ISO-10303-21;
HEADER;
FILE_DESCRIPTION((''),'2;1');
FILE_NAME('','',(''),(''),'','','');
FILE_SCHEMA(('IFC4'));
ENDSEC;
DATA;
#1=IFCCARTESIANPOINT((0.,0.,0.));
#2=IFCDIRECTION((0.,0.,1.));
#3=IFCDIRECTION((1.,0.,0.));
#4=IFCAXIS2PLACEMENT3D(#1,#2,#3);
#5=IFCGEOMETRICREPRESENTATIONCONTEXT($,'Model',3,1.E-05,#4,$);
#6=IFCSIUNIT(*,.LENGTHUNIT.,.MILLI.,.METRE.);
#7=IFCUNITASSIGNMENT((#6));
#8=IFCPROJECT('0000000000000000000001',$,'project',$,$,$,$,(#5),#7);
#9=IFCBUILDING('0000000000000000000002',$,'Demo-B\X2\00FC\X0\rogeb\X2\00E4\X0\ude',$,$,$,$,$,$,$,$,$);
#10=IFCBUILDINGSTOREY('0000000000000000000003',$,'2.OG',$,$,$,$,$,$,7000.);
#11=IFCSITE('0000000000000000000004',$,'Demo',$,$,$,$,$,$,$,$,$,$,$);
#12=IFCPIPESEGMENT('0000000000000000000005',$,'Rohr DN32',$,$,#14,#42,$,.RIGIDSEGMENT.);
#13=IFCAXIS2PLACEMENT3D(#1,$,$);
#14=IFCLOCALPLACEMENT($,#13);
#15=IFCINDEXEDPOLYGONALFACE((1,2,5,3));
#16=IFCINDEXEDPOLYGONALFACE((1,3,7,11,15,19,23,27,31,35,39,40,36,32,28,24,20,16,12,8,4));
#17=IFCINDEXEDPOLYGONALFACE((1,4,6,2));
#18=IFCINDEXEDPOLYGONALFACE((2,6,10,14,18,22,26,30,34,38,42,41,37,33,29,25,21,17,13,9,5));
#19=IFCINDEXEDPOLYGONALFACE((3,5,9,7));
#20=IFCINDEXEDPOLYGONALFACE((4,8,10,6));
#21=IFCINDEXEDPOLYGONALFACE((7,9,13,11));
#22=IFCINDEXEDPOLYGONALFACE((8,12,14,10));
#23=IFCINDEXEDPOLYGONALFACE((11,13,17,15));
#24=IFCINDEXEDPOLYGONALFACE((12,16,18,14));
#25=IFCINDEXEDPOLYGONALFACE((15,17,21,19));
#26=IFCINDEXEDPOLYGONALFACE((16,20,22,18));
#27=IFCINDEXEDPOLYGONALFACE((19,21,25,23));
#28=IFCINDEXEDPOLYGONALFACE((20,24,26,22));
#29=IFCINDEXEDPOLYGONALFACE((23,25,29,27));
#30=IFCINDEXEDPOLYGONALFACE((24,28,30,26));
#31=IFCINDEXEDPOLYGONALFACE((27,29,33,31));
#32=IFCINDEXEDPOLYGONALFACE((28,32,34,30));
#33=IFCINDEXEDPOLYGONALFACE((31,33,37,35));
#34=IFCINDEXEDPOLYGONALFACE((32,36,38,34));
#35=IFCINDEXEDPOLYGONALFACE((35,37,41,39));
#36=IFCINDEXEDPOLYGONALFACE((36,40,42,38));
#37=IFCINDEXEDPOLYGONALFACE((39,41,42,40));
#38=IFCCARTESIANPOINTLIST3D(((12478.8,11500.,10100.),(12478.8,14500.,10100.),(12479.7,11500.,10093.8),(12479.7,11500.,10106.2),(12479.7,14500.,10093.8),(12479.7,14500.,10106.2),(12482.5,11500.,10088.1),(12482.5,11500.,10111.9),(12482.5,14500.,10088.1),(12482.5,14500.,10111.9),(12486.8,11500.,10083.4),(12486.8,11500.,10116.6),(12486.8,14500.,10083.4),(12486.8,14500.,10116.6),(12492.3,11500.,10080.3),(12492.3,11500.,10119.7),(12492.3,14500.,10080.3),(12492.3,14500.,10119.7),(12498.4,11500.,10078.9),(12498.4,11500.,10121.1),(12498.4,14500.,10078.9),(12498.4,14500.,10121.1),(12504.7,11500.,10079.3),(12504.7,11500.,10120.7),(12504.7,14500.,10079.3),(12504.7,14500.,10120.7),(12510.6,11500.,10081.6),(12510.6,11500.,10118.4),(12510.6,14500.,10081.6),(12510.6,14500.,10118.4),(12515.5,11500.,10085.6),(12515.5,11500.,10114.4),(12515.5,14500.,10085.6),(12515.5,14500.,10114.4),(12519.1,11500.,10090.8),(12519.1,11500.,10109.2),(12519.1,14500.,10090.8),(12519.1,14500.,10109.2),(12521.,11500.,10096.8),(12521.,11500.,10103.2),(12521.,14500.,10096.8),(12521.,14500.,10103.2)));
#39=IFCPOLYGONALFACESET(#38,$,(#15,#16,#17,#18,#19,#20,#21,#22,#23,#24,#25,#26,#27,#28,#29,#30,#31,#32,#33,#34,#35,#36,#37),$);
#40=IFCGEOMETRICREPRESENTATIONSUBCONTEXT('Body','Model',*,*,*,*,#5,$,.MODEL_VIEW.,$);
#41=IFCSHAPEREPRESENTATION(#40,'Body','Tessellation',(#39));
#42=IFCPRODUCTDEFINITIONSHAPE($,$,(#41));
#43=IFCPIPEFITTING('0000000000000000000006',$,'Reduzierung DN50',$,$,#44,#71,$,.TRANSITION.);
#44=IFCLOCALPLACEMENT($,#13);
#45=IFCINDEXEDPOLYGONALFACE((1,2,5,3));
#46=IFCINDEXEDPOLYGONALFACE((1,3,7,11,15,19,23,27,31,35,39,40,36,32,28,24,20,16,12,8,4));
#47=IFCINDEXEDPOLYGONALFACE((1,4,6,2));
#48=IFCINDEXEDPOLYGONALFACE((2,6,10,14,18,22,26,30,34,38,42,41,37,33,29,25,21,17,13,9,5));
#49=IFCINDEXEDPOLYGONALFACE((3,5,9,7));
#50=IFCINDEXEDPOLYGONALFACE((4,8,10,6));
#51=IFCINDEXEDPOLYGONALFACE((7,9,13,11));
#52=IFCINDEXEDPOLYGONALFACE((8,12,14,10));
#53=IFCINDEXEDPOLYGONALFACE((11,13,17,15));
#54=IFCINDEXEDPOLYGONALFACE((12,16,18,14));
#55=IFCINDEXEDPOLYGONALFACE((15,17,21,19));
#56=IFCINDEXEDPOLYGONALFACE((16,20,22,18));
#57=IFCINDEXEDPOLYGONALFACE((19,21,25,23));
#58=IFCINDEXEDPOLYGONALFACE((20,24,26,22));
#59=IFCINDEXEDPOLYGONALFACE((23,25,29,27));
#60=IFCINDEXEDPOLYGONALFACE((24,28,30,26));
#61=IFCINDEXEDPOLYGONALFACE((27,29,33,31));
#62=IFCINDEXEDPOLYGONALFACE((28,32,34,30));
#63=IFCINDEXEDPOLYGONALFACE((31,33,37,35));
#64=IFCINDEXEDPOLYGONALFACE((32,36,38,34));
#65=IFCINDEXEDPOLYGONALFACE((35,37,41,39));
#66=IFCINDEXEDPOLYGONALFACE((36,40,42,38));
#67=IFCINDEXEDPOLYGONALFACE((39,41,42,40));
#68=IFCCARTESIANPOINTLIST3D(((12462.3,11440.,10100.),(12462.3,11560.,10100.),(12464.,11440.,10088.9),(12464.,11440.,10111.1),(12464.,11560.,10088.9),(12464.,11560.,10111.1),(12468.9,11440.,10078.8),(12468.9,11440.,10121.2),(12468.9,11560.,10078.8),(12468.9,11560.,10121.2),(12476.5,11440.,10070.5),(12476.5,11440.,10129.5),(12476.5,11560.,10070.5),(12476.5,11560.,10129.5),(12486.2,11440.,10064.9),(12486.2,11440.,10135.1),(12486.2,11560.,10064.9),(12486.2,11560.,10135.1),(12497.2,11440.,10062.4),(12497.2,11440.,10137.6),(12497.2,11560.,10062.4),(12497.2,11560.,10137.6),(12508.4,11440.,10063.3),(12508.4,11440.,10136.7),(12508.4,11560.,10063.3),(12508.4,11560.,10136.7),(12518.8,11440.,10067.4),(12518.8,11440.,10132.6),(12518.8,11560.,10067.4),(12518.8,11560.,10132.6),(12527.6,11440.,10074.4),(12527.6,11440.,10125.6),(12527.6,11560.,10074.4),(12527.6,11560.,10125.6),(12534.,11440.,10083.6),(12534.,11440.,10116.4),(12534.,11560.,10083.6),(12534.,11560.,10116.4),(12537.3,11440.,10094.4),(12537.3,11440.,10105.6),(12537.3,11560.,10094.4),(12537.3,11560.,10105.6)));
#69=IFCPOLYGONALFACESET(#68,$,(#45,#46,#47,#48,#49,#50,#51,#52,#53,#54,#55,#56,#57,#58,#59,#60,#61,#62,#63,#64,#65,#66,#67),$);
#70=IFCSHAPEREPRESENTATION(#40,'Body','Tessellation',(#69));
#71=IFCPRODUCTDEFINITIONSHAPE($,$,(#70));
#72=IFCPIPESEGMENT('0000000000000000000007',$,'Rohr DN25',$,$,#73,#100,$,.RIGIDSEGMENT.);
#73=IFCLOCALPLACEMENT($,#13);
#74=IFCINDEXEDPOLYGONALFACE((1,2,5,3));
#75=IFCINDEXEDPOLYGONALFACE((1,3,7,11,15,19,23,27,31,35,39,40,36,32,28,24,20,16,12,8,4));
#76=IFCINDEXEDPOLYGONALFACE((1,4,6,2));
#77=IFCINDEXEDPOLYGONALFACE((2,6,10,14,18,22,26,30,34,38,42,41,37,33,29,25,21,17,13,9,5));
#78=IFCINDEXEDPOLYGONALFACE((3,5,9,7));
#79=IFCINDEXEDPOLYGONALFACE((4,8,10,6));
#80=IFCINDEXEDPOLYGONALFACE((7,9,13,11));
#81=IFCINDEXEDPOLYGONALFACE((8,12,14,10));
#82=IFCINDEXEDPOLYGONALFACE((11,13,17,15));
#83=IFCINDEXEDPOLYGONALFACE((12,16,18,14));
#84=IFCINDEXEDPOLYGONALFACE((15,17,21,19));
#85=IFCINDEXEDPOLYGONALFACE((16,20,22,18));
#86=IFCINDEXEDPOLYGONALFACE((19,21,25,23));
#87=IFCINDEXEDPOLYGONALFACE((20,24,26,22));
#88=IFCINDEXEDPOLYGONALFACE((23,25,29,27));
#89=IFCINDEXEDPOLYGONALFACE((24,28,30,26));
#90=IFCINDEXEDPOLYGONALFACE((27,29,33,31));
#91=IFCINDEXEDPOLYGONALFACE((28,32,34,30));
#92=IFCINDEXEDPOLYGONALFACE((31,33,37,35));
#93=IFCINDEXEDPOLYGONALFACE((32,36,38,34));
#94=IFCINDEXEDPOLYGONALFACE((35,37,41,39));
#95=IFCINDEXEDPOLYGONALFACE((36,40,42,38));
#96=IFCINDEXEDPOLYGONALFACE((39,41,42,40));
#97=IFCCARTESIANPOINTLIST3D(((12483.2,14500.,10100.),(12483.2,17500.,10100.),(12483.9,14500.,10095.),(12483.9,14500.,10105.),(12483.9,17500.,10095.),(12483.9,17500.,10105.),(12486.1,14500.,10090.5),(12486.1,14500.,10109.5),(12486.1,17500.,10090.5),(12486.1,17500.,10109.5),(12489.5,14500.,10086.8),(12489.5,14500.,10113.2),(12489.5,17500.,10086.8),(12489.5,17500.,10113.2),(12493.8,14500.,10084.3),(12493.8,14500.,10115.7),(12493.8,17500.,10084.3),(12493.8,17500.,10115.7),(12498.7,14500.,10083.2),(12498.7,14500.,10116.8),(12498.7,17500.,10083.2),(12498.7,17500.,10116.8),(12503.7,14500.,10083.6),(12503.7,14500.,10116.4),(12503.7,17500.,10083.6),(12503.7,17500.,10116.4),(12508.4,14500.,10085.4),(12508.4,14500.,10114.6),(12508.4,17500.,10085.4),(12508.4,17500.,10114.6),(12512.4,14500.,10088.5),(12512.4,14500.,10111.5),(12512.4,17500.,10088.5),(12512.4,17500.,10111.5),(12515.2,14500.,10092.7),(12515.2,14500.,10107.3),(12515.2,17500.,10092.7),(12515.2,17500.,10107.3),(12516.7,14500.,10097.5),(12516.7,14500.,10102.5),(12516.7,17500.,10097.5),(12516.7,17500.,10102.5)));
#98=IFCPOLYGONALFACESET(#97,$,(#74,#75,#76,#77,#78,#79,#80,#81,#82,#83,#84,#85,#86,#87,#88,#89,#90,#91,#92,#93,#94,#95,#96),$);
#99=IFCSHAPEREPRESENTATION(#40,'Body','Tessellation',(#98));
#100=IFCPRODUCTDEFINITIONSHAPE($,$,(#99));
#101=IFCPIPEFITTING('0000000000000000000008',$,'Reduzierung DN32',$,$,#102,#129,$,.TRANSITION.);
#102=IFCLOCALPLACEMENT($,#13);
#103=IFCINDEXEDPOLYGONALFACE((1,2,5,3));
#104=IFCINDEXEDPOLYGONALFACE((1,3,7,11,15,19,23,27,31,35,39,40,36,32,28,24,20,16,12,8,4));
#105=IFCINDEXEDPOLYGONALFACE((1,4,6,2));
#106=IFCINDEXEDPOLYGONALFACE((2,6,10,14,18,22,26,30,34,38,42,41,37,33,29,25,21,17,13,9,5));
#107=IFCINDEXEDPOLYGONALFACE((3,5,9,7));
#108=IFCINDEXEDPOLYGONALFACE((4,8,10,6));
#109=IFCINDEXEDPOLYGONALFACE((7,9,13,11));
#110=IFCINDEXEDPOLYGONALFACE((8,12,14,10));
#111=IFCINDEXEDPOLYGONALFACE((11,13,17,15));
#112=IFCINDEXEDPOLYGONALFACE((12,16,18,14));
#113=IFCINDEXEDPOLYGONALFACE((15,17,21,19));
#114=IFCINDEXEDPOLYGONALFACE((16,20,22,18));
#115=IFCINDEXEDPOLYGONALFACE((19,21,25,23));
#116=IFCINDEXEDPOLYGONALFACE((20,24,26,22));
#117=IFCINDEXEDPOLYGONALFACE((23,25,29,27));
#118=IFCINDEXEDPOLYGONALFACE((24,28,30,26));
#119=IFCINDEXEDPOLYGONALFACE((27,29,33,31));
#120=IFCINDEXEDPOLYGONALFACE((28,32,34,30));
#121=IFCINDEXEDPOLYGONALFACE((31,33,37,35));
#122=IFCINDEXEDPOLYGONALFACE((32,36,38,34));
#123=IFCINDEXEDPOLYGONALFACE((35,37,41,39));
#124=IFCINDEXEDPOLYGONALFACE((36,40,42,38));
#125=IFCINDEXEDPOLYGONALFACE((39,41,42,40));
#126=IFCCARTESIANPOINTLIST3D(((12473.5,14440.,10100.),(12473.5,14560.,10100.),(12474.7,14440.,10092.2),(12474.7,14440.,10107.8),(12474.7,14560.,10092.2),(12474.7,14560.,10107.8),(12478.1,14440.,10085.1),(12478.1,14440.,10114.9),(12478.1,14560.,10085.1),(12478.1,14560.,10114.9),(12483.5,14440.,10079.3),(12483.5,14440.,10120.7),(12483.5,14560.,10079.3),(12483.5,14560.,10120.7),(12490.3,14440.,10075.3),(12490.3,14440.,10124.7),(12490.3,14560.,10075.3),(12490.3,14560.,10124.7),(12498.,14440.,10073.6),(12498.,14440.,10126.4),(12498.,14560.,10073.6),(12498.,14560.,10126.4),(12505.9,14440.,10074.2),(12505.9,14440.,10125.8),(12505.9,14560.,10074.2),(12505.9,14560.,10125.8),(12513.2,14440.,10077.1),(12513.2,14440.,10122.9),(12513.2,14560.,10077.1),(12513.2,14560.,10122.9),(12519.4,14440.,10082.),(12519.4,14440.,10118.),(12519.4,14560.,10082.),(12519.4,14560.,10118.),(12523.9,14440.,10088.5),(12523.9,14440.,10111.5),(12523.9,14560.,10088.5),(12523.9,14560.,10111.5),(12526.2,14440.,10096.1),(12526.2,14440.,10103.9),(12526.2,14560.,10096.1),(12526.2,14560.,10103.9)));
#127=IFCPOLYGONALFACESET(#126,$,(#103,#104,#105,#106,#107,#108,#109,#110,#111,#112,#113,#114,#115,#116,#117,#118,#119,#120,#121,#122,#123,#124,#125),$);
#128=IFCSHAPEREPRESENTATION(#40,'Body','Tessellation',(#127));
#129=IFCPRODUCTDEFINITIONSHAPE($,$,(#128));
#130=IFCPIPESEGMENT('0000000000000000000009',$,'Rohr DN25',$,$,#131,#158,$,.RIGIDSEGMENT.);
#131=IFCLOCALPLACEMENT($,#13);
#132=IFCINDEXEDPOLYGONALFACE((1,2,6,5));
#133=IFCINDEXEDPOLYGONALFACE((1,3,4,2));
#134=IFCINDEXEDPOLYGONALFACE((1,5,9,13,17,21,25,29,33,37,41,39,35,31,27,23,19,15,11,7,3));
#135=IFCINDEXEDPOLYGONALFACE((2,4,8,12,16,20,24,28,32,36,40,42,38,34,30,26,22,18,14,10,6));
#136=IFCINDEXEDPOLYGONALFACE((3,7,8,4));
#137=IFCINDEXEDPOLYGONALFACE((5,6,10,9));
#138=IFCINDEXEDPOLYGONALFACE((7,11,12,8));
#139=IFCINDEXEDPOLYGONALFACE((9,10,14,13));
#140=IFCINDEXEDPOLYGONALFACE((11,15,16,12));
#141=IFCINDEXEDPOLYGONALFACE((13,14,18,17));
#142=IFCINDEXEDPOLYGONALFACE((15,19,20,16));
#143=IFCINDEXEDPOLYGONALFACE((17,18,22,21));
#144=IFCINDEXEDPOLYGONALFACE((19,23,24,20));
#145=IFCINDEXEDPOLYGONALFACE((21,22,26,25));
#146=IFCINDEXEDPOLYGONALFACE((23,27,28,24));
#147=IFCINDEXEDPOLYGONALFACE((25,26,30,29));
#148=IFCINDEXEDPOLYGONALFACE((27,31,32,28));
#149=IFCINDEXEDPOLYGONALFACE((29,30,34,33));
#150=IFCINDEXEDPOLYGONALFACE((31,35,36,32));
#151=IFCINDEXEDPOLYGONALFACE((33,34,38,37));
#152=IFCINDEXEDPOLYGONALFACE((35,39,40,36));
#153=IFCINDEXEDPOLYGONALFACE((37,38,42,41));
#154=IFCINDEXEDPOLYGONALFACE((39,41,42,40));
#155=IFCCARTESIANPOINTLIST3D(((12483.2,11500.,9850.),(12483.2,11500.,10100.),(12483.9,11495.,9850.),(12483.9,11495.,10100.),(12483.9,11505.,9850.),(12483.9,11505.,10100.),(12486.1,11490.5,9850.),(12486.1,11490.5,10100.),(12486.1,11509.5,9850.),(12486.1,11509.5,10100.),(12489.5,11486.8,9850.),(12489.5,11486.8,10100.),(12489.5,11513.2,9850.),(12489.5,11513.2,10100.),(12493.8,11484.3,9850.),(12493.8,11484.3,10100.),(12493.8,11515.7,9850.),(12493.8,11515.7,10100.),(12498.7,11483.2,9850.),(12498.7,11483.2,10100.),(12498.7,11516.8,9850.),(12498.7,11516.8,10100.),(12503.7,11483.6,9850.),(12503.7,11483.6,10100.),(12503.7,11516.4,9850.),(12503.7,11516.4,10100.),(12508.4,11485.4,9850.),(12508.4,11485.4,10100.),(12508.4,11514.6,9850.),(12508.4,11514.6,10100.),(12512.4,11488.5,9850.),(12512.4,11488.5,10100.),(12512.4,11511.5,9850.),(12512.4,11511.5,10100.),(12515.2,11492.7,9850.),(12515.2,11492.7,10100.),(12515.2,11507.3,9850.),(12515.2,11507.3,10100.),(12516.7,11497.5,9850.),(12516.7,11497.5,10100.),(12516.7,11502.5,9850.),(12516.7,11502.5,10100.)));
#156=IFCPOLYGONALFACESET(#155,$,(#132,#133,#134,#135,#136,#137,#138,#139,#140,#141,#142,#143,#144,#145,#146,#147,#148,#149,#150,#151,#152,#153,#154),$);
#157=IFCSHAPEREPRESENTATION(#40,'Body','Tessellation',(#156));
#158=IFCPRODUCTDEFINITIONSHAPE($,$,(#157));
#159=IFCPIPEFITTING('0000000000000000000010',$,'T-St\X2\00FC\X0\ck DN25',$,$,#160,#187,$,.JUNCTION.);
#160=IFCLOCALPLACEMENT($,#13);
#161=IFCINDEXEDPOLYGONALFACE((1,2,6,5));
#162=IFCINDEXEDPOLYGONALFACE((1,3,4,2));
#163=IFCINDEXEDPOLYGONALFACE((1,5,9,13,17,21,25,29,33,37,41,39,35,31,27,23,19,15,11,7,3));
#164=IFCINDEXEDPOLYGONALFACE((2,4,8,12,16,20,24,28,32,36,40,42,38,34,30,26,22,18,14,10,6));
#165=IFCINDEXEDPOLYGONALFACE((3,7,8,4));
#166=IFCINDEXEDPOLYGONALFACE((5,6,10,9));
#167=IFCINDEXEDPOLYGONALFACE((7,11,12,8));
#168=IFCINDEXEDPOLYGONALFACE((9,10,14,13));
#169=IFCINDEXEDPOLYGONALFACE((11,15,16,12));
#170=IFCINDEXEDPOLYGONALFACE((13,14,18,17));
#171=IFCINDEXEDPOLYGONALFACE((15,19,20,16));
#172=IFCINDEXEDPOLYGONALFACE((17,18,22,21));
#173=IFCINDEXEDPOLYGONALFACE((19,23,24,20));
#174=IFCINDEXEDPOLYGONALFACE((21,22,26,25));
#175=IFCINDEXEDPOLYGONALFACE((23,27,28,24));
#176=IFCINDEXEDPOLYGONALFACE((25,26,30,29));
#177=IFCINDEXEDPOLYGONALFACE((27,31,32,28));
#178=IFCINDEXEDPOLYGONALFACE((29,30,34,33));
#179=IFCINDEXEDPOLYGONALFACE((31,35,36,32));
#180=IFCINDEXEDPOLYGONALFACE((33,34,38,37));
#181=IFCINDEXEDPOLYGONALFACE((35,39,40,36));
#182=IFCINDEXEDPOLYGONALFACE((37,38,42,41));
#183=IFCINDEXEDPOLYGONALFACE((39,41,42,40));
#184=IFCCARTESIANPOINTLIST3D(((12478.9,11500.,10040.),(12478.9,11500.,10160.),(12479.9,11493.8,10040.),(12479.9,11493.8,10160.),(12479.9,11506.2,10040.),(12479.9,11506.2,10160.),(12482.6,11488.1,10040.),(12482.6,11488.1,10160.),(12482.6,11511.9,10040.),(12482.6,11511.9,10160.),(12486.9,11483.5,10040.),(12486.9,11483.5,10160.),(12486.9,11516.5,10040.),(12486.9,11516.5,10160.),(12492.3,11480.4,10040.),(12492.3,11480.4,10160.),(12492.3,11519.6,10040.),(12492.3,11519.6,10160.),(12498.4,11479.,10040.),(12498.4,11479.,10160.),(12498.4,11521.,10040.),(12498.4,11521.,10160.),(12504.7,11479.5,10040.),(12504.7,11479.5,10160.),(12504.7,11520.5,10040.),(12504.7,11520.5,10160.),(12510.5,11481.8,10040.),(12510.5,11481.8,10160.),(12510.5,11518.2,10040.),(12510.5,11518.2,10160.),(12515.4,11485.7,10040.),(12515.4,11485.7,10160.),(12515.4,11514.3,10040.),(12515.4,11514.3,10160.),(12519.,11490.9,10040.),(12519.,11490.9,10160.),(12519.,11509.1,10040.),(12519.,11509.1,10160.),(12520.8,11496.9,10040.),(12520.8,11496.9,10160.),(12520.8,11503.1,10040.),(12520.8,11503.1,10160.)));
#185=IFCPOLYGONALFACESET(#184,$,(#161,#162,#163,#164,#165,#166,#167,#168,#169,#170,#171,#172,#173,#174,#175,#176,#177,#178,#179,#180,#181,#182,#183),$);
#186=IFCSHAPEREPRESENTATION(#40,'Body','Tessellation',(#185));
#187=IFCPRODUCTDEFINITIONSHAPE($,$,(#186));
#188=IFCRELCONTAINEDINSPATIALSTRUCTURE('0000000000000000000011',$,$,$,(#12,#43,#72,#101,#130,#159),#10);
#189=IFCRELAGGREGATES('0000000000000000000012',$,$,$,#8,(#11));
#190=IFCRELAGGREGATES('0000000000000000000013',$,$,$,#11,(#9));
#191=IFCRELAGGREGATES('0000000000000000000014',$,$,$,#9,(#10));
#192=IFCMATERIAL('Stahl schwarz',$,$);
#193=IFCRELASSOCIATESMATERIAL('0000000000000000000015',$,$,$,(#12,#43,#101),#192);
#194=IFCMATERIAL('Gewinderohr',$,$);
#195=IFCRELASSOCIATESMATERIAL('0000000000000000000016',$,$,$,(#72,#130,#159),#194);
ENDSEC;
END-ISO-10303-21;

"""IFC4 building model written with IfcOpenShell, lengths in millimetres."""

from ifc_helpers import new_model, si_unit, frame, origin_with_axes, place, context, subcontext, project, spatial, circle, extrude, material, element, save


model = new_model("IFC4")

# Units and contexts
model_context = context("Model", 3, precision=1e-05, world=origin_with_axes())
body_context = subcontext(model_context, "Body", "Model", "MODEL_VIEW")
ifc_project = project(units=[si_unit("LENGTHUNIT", "METRE", prefix="MILLI")], contexts=[model_context])

# Site, building, storey
site = spatial("IfcSite", under=ifc_project, Name="Demo")
building = spatial("IfcBuilding", under=site, Name="Demo-Bürogebäude")
storey = spatial("IfcBuildingStorey", under=building, Name="2.OG", Elevation=7000.0)

# Pipe segment
ifc_material_1 = material(Name="Stahl schwarz")
pipe_segment_1_placement = place(None, frame((12500.0, 11500.0, 10100.0), z_axis=(0.0, 1.0, 0.0), x_axis=(-1.0, 0.0, 0.0)))
element("IfcPipeSegment", 1, at=pipe_segment_1_placement, inside=storey, material=ifc_material_1, Name="Rohr DN32", PredefinedType="RIGIDSEGMENT", context=body_context, shape_type="SweptSolid", body=[
    extrude(circle(Radius=21.2), origin_with_axes(), (0.0, 0.0, 1.0), 3000.0),
])

# Pipe fitting
pipe_fitting_1_placement = place(None, frame((12500.0, 11440.0, 10100.0), z_axis=(0.0, 1.0, 0.0), x_axis=(-1.0, 0.0, 0.0)))
element("IfcPipeFitting", 2, at=pipe_fitting_1_placement, inside=storey, material=ifc_material_1, Name="Reduzierung DN50", PredefinedType="TRANSITION", context=body_context, shape_type="SweptSolid", body=[
    extrude(circle(Radius=37.7), origin_with_axes(), (0.0, 0.0, 1.0), 120.0),
])

# Pipe segment
ifc_material_2 = material(Name="Gewinderohr")
pipe_segment_2_placement = place(None, frame((12500.0, 14500.0, 10100.0), z_axis=(0.0, 1.0, 0.0), x_axis=(-1.0, 0.0, 0.0)))
element("IfcPipeSegment", 3, at=pipe_segment_2_placement, inside=storey, material=ifc_material_2, Name="Rohr DN25", PredefinedType="RIGIDSEGMENT", context=body_context, shape_type="SweptSolid", body=[
    extrude(circle(Radius=16.9), origin_with_axes(), (0.0, 0.0, 1.0), 3000.0),
])

# Pipe fitting
pipe_fitting_2_placement = place(None, frame((12500.0, 14440.0, 10100.0), z_axis=(0.0, 1.0, 0.0), x_axis=(-1.0, 0.0, 0.0)))
element("IfcPipeFitting", 4, at=pipe_fitting_2_placement, inside=storey, material=ifc_material_1, Name="Reduzierung DN32", PredefinedType="TRANSITION", context=body_context, shape_type="SweptSolid", body=[
    extrude(circle(Radius=26.5), origin_with_axes(), (0.0, 0.0, 1.0), 120.0),
])

# Pipe segment
pipe_segment_3_placement = place(None, frame((12500.0, 11500.0, 10100.0), z_axis=(0.0, 0.0, -1.0), x_axis=(-1.0, 0.0, 0.0)))
element("IfcPipeSegment", 5, at=pipe_segment_3_placement, inside=storey, material=ifc_material_2, Name="Rohr DN25", PredefinedType="RIGIDSEGMENT", context=body_context, shape_type="SweptSolid", body=[
    extrude(circle(Radius=16.9), origin_with_axes(), (0.0, 0.0, 1.0), 250.0),
])

# Pipe fitting
pipe_fitting_3_placement = place(None, frame((12500.0, 11500.0, 10160.0), z_axis=(0.0, 0.0, -1.0), x_axis=(-1.0, 0.0, 0.0)))
element("IfcPipeFitting", 6, at=pipe_fitting_3_placement, inside=storey, material=ifc_material_2, Name="T-Stück DN25", PredefinedType="JUNCTION", context=body_context, shape_type="SweptSolid", body=[
    extrude(circle(Radius=21.1), origin_with_axes(), (0.0, 0.0, 1.0), 120.0),
])

save(model, "model.ifc")
